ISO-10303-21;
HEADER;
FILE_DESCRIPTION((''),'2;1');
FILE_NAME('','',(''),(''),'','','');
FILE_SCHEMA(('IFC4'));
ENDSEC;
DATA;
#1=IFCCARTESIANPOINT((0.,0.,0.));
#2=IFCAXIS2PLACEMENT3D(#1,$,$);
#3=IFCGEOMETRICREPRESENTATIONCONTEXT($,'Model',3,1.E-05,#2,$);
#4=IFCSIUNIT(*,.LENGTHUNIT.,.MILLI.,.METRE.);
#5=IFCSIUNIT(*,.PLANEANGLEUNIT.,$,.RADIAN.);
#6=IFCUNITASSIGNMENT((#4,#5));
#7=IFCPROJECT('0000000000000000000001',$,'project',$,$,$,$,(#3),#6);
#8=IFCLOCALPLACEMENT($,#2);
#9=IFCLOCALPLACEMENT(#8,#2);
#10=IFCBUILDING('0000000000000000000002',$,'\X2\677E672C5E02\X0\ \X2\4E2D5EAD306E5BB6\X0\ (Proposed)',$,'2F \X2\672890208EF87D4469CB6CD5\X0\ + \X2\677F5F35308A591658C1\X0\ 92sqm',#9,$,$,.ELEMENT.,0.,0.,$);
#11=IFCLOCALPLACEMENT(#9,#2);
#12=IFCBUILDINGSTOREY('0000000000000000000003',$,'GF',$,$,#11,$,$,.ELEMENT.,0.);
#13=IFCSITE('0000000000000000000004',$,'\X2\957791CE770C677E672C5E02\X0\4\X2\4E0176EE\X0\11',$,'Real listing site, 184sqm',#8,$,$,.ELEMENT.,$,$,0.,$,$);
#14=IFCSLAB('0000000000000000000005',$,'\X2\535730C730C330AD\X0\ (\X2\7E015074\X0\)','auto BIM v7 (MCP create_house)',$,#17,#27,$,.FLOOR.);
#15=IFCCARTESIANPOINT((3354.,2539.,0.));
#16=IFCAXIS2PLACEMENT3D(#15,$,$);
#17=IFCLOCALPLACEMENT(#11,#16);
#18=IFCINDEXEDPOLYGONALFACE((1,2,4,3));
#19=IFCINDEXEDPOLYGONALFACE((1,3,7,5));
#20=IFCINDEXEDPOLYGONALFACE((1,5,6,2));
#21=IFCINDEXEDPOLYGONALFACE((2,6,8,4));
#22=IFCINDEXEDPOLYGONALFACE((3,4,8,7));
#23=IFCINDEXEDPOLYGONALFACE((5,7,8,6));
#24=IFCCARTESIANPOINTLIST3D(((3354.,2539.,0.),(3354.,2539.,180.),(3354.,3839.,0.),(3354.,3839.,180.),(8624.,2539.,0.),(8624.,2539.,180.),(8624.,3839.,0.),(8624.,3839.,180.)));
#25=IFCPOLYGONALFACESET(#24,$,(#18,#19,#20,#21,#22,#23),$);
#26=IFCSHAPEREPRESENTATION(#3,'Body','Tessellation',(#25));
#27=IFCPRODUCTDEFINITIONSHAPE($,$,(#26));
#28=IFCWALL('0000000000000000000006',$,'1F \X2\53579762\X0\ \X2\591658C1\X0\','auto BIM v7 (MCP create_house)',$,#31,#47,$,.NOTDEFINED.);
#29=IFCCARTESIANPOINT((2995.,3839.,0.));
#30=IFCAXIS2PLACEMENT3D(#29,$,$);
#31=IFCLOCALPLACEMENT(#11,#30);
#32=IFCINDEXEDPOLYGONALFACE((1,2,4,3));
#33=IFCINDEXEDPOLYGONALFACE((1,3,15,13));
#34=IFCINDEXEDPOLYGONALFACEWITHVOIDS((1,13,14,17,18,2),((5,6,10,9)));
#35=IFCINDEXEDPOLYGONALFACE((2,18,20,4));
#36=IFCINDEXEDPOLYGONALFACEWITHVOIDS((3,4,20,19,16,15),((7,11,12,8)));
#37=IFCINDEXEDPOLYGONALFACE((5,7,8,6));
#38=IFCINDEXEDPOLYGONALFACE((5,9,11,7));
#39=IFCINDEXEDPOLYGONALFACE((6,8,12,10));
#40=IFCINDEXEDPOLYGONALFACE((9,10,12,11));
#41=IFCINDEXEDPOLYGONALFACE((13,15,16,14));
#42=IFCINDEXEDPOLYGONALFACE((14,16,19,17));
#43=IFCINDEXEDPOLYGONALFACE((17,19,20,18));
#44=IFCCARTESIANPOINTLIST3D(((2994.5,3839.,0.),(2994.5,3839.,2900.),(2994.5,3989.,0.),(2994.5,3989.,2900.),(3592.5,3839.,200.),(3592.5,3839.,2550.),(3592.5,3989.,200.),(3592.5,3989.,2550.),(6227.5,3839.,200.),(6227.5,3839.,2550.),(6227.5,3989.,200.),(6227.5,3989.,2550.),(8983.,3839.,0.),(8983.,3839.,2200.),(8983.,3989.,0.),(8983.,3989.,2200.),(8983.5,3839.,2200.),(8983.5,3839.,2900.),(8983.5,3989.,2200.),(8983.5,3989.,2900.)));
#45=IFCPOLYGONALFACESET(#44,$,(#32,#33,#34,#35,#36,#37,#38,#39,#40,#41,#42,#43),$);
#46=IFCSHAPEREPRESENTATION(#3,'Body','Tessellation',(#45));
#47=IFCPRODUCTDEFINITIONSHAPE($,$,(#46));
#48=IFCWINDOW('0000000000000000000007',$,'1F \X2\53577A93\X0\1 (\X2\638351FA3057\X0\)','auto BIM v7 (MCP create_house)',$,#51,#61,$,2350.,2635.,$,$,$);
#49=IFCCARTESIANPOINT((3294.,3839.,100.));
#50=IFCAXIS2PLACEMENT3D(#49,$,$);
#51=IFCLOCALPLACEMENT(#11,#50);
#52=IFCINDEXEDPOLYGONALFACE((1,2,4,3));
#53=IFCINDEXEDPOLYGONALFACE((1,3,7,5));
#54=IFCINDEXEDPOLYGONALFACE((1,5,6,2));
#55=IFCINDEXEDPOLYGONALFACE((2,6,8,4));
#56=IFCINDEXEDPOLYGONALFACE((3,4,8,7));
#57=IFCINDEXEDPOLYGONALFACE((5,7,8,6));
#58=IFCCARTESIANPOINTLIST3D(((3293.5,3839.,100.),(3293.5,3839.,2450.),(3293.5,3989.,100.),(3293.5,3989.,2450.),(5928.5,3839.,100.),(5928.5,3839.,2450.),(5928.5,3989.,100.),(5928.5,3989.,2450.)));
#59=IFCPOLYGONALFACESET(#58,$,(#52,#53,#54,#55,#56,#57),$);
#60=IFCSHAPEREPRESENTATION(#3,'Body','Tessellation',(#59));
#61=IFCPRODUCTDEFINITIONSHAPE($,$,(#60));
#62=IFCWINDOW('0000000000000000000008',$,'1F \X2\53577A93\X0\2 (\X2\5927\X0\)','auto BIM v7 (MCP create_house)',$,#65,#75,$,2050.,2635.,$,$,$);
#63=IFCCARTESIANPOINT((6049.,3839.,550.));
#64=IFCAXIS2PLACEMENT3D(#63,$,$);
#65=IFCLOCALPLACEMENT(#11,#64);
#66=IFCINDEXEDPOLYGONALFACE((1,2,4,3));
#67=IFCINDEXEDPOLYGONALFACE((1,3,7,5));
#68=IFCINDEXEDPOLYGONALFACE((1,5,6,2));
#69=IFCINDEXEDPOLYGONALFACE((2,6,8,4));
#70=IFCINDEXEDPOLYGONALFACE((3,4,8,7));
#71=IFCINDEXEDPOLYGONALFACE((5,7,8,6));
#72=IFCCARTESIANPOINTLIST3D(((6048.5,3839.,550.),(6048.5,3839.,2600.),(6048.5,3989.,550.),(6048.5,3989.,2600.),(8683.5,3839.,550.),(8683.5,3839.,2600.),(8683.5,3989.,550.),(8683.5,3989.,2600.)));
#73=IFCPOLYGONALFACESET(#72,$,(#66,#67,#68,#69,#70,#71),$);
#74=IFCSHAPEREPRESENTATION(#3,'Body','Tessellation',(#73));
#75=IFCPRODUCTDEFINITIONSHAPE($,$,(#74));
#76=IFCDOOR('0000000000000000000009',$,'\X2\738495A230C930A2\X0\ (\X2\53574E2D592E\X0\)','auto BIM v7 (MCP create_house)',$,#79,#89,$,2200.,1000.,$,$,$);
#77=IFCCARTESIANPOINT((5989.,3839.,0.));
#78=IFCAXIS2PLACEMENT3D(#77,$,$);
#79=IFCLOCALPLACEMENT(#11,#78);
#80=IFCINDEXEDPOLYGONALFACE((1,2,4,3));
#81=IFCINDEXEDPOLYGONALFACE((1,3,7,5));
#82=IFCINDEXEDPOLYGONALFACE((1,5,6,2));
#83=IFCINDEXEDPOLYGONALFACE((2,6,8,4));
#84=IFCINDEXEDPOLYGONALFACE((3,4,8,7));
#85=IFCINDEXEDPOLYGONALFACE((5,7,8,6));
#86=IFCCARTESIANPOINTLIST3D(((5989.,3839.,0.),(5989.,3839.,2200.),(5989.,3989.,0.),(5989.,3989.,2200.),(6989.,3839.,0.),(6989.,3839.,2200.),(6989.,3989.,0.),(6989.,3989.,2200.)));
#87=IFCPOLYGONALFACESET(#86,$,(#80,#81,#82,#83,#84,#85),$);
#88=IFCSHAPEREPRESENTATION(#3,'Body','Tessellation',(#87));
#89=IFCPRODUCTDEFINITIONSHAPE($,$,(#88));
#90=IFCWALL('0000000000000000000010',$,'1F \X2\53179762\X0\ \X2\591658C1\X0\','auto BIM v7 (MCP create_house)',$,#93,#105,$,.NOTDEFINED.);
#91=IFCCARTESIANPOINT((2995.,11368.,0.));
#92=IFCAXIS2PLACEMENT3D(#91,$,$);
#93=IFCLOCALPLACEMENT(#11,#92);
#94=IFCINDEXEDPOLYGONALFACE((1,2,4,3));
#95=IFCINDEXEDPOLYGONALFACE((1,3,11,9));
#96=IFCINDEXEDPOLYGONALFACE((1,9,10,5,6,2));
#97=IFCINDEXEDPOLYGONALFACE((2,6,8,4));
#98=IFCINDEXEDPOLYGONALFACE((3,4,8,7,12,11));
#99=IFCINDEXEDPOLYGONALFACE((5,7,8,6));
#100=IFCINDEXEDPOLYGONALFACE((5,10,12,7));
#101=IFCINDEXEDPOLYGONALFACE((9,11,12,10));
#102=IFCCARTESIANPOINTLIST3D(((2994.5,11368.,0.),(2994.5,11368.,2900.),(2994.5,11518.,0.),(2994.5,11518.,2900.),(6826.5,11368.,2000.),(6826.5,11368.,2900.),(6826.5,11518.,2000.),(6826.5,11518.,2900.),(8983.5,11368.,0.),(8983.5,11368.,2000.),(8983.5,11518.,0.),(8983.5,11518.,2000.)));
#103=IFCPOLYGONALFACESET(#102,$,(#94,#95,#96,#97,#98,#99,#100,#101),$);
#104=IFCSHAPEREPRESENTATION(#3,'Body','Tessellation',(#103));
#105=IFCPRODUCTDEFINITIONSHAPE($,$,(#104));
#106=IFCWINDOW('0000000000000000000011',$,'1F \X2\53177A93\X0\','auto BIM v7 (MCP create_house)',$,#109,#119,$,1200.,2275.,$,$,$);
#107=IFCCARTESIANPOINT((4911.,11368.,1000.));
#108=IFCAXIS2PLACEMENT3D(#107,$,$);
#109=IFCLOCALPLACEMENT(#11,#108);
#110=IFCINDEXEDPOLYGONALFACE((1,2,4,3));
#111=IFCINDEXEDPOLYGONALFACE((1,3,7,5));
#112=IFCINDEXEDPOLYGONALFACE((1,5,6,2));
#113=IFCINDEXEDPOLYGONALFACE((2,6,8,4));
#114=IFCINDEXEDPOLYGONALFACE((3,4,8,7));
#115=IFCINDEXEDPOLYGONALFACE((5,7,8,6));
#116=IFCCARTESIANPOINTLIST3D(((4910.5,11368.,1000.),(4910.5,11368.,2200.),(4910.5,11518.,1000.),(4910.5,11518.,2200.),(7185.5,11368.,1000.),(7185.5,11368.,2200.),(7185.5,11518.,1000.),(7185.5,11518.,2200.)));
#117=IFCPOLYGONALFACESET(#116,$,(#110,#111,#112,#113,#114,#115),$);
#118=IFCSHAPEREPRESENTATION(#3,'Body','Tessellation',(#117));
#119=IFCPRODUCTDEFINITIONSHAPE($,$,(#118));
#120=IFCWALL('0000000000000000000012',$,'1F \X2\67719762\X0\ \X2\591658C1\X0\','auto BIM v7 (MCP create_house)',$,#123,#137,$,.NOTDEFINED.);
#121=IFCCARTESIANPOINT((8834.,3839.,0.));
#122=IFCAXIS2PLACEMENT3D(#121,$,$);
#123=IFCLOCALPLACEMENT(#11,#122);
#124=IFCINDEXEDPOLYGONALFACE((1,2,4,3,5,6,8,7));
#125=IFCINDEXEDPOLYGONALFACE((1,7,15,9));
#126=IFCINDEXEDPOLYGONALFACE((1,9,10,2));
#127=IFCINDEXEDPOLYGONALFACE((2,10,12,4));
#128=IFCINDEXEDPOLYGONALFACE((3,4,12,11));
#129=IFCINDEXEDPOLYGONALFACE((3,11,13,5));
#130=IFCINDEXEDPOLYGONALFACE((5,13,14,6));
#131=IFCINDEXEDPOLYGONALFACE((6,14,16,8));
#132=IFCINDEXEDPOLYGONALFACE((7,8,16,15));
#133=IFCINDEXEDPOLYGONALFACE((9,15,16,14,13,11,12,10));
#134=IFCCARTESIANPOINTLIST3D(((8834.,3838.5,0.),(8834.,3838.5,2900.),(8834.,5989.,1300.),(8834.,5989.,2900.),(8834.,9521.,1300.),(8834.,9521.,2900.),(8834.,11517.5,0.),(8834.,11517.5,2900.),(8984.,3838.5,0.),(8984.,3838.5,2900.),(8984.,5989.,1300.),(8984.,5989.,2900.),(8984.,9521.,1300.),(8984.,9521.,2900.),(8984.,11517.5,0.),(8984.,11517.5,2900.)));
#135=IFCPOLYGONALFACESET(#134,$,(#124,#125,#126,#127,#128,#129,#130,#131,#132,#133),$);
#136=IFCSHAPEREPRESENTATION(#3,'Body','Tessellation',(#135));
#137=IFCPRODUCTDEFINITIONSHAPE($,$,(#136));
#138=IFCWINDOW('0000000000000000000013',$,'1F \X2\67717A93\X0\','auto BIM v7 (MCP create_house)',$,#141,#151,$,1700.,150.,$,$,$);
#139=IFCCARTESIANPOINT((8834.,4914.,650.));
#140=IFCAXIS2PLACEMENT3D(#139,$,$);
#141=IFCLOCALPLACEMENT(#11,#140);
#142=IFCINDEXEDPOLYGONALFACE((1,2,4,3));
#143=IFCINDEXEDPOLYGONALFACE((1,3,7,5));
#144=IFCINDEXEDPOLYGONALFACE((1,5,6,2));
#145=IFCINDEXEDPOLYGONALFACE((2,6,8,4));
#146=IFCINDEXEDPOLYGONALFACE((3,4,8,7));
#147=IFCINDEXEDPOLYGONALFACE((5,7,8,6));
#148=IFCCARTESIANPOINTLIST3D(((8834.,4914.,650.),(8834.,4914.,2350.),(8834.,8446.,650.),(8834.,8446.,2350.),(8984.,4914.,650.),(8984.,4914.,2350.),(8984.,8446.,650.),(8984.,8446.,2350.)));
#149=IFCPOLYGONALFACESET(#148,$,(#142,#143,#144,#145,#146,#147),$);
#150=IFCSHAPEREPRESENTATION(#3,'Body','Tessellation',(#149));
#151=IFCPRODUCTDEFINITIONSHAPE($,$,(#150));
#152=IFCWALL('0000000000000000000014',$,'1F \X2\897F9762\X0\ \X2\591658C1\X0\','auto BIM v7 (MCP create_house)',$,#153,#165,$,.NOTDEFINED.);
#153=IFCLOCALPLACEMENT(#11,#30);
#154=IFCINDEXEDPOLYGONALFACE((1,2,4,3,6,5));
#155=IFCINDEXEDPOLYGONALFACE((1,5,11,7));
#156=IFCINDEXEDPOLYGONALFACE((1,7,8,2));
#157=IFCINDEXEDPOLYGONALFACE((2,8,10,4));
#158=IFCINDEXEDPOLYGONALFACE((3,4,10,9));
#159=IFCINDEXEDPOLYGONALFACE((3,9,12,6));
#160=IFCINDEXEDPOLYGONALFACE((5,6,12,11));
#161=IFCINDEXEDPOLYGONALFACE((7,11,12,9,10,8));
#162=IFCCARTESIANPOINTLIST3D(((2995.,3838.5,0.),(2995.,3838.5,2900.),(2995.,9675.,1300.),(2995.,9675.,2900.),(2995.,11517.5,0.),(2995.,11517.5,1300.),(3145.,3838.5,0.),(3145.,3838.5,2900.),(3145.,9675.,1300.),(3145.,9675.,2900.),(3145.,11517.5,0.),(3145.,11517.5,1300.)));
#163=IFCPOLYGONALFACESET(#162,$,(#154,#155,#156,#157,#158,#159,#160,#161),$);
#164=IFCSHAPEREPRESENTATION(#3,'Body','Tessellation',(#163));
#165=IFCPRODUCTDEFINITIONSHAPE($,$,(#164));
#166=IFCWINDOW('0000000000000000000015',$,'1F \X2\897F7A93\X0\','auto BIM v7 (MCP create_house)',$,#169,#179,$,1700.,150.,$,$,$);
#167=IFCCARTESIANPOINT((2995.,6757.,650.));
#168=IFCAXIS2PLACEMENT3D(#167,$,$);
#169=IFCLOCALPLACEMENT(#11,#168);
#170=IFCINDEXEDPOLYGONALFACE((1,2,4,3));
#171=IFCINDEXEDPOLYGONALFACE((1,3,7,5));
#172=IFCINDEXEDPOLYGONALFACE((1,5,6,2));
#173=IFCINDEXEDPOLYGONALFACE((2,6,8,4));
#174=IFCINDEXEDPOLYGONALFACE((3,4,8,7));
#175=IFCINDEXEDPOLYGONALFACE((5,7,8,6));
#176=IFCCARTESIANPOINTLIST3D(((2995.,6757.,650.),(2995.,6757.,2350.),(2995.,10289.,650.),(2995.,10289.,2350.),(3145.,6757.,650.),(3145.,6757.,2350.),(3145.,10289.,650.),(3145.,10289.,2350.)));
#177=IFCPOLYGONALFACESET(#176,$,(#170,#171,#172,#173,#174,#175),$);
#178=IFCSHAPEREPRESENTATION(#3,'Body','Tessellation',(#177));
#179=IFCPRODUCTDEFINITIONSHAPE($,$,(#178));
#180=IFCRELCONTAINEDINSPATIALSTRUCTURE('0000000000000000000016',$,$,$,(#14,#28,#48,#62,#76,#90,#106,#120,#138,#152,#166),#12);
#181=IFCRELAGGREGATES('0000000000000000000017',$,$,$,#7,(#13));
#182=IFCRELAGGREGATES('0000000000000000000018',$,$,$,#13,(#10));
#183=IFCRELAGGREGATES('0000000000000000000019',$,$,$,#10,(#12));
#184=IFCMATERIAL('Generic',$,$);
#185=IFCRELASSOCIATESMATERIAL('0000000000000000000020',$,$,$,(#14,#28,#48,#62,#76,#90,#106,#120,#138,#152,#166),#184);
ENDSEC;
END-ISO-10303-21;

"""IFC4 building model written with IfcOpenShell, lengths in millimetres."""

from ifc_helpers import new_model, si_unit, frame, frame_2d, origin, place, context, project, spatial, rectangle, extrude, material, element, fill, save


model = new_model("IFC4")

# Units and contexts
model_context = context("Model", 3, precision=1e-05, world=origin())
ifc_project = project(units=[si_unit("LENGTHUNIT", "METRE", prefix="MILLI"), si_unit("PLANEANGLEUNIT", "RADIAN")], contexts=[model_context])

# Site, building, storey
site_placement = place(None, origin())
site = spatial("IfcSite", under=ifc_project, at=site_placement, Name="長野県松本市4丁目11", ObjectType="Real listing site, 184sqm", CompositionType="ELEMENT", RefElevation=0.0)
building_placement = place(site_placement, origin())
building = spatial("IfcBuilding", under=site, at=building_placement, Name="松本市 中庭の家 (Proposed)", ObjectType="2F 木造軸組構法 + 板張り外壁 92sqm", CompositionType="ELEMENT", ElevationOfRefHeight=0.0, ElevationOfTerrain=0.0)
storey_placement = place(building_placement, origin())
storey = spatial("IfcBuildingStorey", under=building, at=storey_placement, Name="GF", CompositionType="ELEMENT", Elevation=0.0)

# Slab
ifc_material = material(Name="Generic")
slab_1_placement = place(storey_placement, frame((3354.0, 2539.0, 0.0)))
element("IfcSlab", 1, at=slab_1_placement, inside=storey, material=ifc_material, Name="南デッキ (縁側)", Description="auto BIM v7 (MCP create_house)", PredefinedType="FLOOR", context=model_context, shape_type="SweptSolid", body=[
    extrude(rectangle(XDim=5270.0, YDim=1300.0, at=frame_2d((2635.0, 650.0))), frame((3354.0, 2539.0, 0.0)), (0.0, 0.0, 1.0), 180.0),
])

# Wall, openings, windows, door
wall_1_placement = place(storey_placement, frame((2995.0, 3839.0, 0.0)))
wall_1 = element("IfcWall", 2, at=wall_1_placement, inside=storey, material=ifc_material, Name="1F 南面 外壁", Description="auto BIM v7 (MCP create_house)", PredefinedType="NOTDEFINED", context=model_context, shape_type="SweptSolid", body=[
    extrude(rectangle(XDim=5989.0, YDim=150.0, at=frame_2d((2994.0, 75.0))), frame((2995.0, 3839.0, 0.0)), (0.0, 0.0, 1.0), 2900.0),
])
opening_1_placement = place(storey_placement, frame((3294.0, 3839.0, 100.0)))
opening_1 = element("IfcOpeningElement", 3, at=opening_1_placement, cuts=wall_1, PredefinedType="NOTDEFINED", context=model_context, shape_type="SweptSolid", body=[
    extrude(rectangle(XDim=2635.0, YDim=150.0, at=frame_2d((1317.0, 75.0))), frame((3294.0, 3839.0, 100.0)), (0.0, 0.0, 1.0), 2350.0),
])
opening_2_placement = place(storey_placement, frame((6049.0, 3839.0, 550.0)))
opening_2 = element("IfcOpeningElement", 4, at=opening_2_placement, cuts=wall_1, PredefinedType="NOTDEFINED", context=model_context, shape_type="SweptSolid", body=[
    extrude(rectangle(XDim=2635.0, YDim=150.0, at=frame_2d((1317.0, 75.0))), frame((6049.0, 3839.0, 550.0)), (0.0, 0.0, 1.0), 2050.0),
])
opening_3_placement = place(storey_placement, frame((5989.0, 3839.0, 0.0)))
opening_3 = element("IfcOpeningElement", 5, at=opening_3_placement, cuts=wall_1, PredefinedType="NOTDEFINED", context=model_context, shape_type="SweptSolid", body=[
    extrude(rectangle(XDim=1000.0, YDim=150.0, at=frame_2d((500.0, 75.0))), frame((5989.0, 3839.0, 0.0)), (0.0, 0.0, 1.0), 2200.0),
])
window_1_placement = place(storey_placement, frame((3294.0, 3839.0, 100.0)))
window_1 = element("IfcWindow", 6, at=window_1_placement, inside=storey, material=ifc_material, Name="1F 南窓1 (掃出し)", Description="auto BIM v7 (MCP create_house)", OverallHeight=2350.0, OverallWidth=2635.0, context=model_context, shape_type="SweptSolid", body=[
    extrude(rectangle(XDim=2635.0, YDim=150.0, at=frame_2d((1317.0, 75.0))), frame((3294.0, 3839.0, 100.0)), (0.0, 0.0, 1.0), 2350.0),
])
fill(opening_1, window_1)
window_2_placement = place(storey_placement, frame((6049.0, 3839.0, 550.0)))
window_2 = element("IfcWindow", 7, at=window_2_placement, inside=storey, material=ifc_material, Name="1F 南窓2 (大)", Description="auto BIM v7 (MCP create_house)", OverallHeight=2050.0, OverallWidth=2635.0, context=model_context, shape_type="SweptSolid", body=[
    extrude(rectangle(XDim=2635.0, YDim=150.0, at=frame_2d((1317.0, 75.0))), frame((6049.0, 3839.0, 550.0)), (0.0, 0.0, 1.0), 2050.0),
])
fill(opening_2, window_2)
door_placement = place(storey_placement, frame((5989.0, 3839.0, 0.0)))
door = element("IfcDoor", 8, at=door_placement, inside=storey, material=ifc_material, Name="玄関ドア (南中央)", Description="auto BIM v7 (MCP create_house)", OverallHeight=2200.0, OverallWidth=1000.0, context=model_context, shape_type="SweptSolid", body=[
    extrude(rectangle(XDim=1000.0, YDim=150.0, at=frame_2d((500.0, 75.0))), frame((5989.0, 3839.0, 0.0)), (0.0, 0.0, 1.0), 2200.0),
])
fill(opening_3, door)

# Walls, openings, windows
wall_2_placement = place(storey_placement, frame((2995.0, 11368.0, 0.0)))
wall_2 = element("IfcWall", 9, at=wall_2_placement, inside=storey, material=ifc_material, Name="1F 北面 外壁", Description="auto BIM v7 (MCP create_house)", PredefinedType="NOTDEFINED", context=model_context, shape_type="SweptSolid", body=[
    extrude(rectangle(XDim=5989.0, YDim=150.0, at=frame_2d((2994.0, 75.0))), frame((2995.0, 11368.0, 0.0)), (0.0, 0.0, 1.0), 2900.0),
])
opening_4_placement = place(storey_placement, frame((4911.0, 11368.0, 1000.0)))
opening_4 = element("IfcOpeningElement", 10, at=opening_4_placement, cuts=wall_2, PredefinedType="NOTDEFINED", context=model_context, shape_type="SweptSolid", body=[
    extrude(rectangle(XDim=2275.0, YDim=150.0, at=frame_2d((1137.0, 75.0))), frame((4911.0, 11368.0, 1000.0)), (0.0, 0.0, 1.0), 1200.0),
])
window_3_placement = place(storey_placement, frame((4911.0, 11368.0, 1000.0)))
window_3 = element("IfcWindow", 11, at=window_3_placement, inside=storey, material=ifc_material, Name="1F 北窓", Description="auto BIM v7 (MCP create_house)", OverallHeight=1200.0, OverallWidth=2275.0, context=model_context, shape_type="SweptSolid", body=[
    extrude(rectangle(XDim=2275.0, YDim=150.0, at=frame_2d((1137.0, 75.0))), frame((4911.0, 11368.0, 1000.0)), (0.0, 0.0, 1.0), 1200.0),
])
fill(opening_4, window_3)
wall_3_placement = place(storey_placement, frame((8834.0, 3839.0, 0.0)))
wall_3 = element("IfcWall", 12, at=wall_3_placement, inside=storey, material=ifc_material, Name="1F 東面 外壁", Description="auto BIM v7 (MCP create_house)", PredefinedType="NOTDEFINED", context=model_context, shape_type="SweptSolid", body=[
    extrude(rectangle(XDim=150.0, YDim=7679.0, at=frame_2d((75.0, 3839.0))), frame((8834.0, 3839.0, 0.0)), (0.0, 0.0, 1.0), 2900.0),
])
opening_5_placement = place(storey_placement, frame((8834.0, 4914.0, 650.0)))
opening_5 = element("IfcOpeningElement", 13, at=opening_5_placement, cuts=wall_3, PredefinedType="NOTDEFINED", context=model_context, shape_type="SweptSolid", body=[
    extrude(rectangle(XDim=150.0, YDim=3532.0, at=frame_2d((75.0, 1766.0))), frame((8834.0, 4914.0, 650.0)), (0.0, 0.0, 1.0), 1700.0),
])
window_4_placement = place(storey_placement, frame((8834.0, 4914.0, 650.0)))
window_4 = element("IfcWindow", 14, at=window_4_placement, inside=storey, material=ifc_material, Name="1F 東窓", Description="auto BIM v7 (MCP create_house)", OverallHeight=1700.0, OverallWidth=150.0, context=model_context, shape_type="SweptSolid", body=[
    extrude(rectangle(XDim=150.0, YDim=3532.0, at=frame_2d((75.0, 1766.0))), frame((8834.0, 4914.0, 650.0)), (0.0, 0.0, 1.0), 1700.0),
])
fill(opening_5, window_4)
wall_4_placement = place(storey_placement, frame((2995.0, 3839.0, 0.0)))
wall_4 = element("IfcWall", 15, at=wall_4_placement, inside=storey, material=ifc_material, Name="1F 西面 外壁", Description="auto BIM v7 (MCP create_house)", PredefinedType="NOTDEFINED", context=model_context, shape_type="SweptSolid", body=[
    extrude(rectangle(XDim=150.0, YDim=7679.0, at=frame_2d((75.0, 3839.0))), frame((2995.0, 3839.0, 0.0)), (0.0, 0.0, 1.0), 2900.0),
])
opening_6_placement = place(storey_placement, frame((2995.0, 6757.0, 650.0)))
opening_6 = element("IfcOpeningElement", 16, at=opening_6_placement, cuts=wall_4, PredefinedType="NOTDEFINED", context=model_context, shape_type="SweptSolid", body=[
    extrude(rectangle(XDim=150.0, YDim=3532.0, at=frame_2d((75.0, 1766.0))), frame((2995.0, 6757.0, 650.0)), (0.0, 0.0, 1.0), 1700.0),
])
window_5_placement = place(storey_placement, frame((2995.0, 6757.0, 650.0)))
window_5 = element("IfcWindow", 17, at=window_5_placement, inside=storey, material=ifc_material, Name="1F 西窓", Description="auto BIM v7 (MCP create_house)", OverallHeight=1700.0, OverallWidth=150.0, context=model_context, shape_type="SweptSolid", body=[
    extrude(rectangle(XDim=150.0, YDim=3532.0, at=frame_2d((75.0, 1766.0))), frame((2995.0, 6757.0, 650.0)), (0.0, 0.0, 1.0), 1700.0),
])
fill(opening_6, window_5)

save(model, "model.ifc")
